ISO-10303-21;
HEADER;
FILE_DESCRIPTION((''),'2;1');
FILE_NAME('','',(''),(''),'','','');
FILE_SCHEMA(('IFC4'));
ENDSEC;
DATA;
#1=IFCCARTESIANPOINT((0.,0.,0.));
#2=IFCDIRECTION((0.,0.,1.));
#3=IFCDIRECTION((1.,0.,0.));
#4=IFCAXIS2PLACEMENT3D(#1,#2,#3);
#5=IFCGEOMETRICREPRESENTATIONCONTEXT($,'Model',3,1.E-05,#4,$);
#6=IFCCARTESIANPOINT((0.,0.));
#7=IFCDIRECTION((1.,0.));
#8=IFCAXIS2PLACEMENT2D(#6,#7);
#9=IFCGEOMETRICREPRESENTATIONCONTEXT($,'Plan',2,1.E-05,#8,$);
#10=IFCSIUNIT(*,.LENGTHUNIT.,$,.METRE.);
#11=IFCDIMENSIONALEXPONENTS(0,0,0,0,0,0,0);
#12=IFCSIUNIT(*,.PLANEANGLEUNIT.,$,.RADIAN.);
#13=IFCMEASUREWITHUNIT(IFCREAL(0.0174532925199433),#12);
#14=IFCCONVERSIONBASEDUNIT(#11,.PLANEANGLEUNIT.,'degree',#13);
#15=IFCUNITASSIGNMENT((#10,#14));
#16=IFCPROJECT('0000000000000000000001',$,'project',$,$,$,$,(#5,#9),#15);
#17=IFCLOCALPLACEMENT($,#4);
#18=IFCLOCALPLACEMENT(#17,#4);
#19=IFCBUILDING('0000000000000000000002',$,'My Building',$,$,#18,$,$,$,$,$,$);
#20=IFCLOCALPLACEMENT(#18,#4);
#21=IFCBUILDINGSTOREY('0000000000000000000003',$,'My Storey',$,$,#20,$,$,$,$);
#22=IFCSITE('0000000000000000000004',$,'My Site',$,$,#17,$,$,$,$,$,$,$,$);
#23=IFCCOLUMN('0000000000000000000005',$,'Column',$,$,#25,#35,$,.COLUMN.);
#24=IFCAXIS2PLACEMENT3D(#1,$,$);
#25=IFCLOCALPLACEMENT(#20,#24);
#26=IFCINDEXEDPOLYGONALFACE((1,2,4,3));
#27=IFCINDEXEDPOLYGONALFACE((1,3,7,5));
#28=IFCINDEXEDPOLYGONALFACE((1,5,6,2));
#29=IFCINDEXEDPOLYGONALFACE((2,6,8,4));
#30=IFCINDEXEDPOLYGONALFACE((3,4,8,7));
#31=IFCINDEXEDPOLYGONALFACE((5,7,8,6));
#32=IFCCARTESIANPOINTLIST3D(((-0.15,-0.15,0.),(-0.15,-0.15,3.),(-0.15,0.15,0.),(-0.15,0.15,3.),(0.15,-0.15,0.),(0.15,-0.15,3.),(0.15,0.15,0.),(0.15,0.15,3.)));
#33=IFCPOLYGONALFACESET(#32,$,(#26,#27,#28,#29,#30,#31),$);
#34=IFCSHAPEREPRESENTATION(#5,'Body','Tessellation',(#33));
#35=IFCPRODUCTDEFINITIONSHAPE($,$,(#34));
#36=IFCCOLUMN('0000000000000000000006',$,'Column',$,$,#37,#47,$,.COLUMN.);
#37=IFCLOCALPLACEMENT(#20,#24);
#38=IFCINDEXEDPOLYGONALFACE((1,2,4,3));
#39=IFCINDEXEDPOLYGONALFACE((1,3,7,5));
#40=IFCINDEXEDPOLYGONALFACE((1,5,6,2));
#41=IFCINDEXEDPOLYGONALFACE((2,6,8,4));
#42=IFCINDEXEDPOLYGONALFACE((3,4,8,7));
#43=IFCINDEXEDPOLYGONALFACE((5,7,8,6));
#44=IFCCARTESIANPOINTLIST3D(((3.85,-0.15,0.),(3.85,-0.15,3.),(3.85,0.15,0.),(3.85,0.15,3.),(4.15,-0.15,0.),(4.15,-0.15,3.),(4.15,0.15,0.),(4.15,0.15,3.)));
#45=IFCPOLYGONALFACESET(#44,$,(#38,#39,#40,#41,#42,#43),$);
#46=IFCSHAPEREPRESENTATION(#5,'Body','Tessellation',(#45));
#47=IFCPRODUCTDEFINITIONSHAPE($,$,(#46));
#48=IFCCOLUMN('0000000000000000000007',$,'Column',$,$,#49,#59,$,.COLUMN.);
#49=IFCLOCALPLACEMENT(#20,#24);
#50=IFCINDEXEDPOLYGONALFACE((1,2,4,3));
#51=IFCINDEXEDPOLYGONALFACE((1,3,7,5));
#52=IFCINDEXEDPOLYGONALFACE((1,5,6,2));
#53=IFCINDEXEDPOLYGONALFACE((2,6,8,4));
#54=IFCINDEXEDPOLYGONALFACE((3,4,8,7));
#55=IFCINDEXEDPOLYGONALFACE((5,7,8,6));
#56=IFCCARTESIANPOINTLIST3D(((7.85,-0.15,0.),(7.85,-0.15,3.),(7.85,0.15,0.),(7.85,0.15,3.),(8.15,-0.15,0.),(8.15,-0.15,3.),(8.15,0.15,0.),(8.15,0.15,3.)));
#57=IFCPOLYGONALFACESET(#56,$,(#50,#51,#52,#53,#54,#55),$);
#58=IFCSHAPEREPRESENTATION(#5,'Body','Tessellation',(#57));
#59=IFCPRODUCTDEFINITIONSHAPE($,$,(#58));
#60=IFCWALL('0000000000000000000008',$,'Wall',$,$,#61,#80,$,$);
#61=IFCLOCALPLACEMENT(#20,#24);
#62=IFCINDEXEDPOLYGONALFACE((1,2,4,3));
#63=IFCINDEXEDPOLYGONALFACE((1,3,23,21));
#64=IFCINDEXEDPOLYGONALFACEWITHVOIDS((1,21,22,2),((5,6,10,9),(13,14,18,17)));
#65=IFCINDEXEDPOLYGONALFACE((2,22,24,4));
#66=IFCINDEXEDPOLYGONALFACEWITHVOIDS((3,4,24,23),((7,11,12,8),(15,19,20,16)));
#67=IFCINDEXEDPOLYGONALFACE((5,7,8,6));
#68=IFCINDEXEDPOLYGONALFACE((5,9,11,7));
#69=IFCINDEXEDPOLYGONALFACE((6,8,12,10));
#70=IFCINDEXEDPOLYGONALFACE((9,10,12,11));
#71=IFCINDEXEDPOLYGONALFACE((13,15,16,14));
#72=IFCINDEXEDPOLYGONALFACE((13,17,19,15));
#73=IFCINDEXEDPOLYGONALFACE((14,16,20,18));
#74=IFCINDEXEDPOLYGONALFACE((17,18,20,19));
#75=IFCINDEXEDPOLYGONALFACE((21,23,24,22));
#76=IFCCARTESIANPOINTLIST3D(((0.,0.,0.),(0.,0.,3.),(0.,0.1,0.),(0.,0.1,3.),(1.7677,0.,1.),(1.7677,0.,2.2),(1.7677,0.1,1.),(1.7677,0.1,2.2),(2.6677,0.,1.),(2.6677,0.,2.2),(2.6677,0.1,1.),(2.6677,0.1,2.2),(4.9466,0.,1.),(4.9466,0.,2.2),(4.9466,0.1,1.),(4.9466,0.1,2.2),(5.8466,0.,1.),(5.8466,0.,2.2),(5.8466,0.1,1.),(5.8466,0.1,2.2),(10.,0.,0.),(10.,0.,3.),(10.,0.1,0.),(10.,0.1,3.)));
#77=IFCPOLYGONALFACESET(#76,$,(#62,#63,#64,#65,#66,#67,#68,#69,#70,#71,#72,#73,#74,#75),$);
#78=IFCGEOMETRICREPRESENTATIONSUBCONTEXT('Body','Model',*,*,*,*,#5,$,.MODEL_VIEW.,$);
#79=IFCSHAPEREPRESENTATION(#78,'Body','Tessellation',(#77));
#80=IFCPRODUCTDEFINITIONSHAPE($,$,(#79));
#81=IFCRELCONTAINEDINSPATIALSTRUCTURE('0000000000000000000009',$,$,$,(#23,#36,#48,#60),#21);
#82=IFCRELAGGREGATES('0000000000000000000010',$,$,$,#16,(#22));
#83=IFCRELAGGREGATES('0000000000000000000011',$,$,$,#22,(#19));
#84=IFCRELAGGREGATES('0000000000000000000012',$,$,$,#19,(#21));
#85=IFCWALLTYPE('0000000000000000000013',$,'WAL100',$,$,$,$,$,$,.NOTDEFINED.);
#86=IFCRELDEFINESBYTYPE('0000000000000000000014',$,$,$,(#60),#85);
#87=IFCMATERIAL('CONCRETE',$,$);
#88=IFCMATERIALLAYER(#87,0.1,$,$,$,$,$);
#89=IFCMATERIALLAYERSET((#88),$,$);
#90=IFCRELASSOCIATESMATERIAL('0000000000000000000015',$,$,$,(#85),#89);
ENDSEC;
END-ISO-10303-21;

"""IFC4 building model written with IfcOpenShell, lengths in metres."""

from ifc_helpers import new_model, entity, si_unit, converted_unit, frame, origin, origin_with_axes, origin_2d, origin_2d_with_axis, place, context, subcontext, project, spatial, line, indexed_curve, rectangle, outline, extrude, source, transform, mapped, material, layer, layer_set, type_object, element, save


model = new_model("IFC4")

# Units and contexts
model_context = context("Model", 3, precision=1e-05, world=origin_with_axes())
plan_context = context("Plan", 2, precision=1e-05, world=origin_2d_with_axis())
body_context = subcontext(model_context, "Body", "Model", "MODEL_VIEW")
ifc_project = project(units=[si_unit("LENGTHUNIT", "METRE"), converted_unit("PLANEANGLEUNIT", "degree", entity("IfcReal", 0.0174532925199433), si_unit("PLANEANGLEUNIT", "RADIAN"), dimensions=[0, 0, 0, 0, 0, 0, 0])], contexts=[model_context, plan_context])

# Site, building, storey
site_placement = place(None, origin_with_axes())
site = spatial("IfcSite", under=ifc_project, at=site_placement, Name="My Site")
building_placement = place(site_placement, origin_with_axes())
building = spatial("IfcBuilding", under=site, at=building_placement, Name="My Building")
storey_placement = place(building_placement, origin_with_axes())
storey = spatial("IfcBuildingStorey", under=building, at=storey_placement, Name="My Storey")

# Columns
for number, where, z_axis, x_axis, name in (
    (1, (0.0, 0.0, 0.0), (0.0, 0.0, 1.0), (1.0, 0.0, 0.0), "Column"),
    (2, (4.0, 0.0, 0.0), (0.0, 0.0, 1.0), (1.0, 0.0, 0.0), "Column"),
    (3, (8.0, 0.0, 0.0), (0.0, 0.0, 1.0), (1.0, 0.0, 0.0), "Column"),
):
    element("IfcColumn", number, at=place(storey_placement, frame(where, z_axis=z_axis, x_axis=x_axis)), inside=storey, Name=name, PredefinedType="COLUMN", context=model_context, shape_type="SweptSolid", body=[
        extrude(rectangle(XDim=0.3, YDim=0.3, at=origin_2d()), origin(), (0.0, 0.0, 1.0), 3.0),
    ])

# Wall, openings
ifc_material = material(Name="CONCRETE")
ifc_layer = layer(ifc_material, 0.1)
ifc_layer_set = layer_set([ifc_layer])
wall_type = type_object("IfcWallType", Name="WAL100", PredefinedType="NOTDEFINED", material=ifc_layer_set)
wall_placement = place(storey_placement, origin_with_axes())
wall = element("IfcWall", 4, at=wall_placement, inside=storey, type_object=wall_type, Name="Wall", context=body_context, shape_type="SweptSolid", body=[
    extrude(outline(indexed_curve([(0.0, 0.0), (0.0, 0.1), (10.0, 0.1), (10.0, 0.0), (0.0, 0.0)], self_intersect=False)), origin_with_axes(), (0.0, 0.0, 1.0), 3.0),
])
shared_shape = source(origin_with_axes(), body_context, "Body", "SweptSolid", [
    extrude(outline(indexed_curve([(0.0, 0.0), (0.9, 0.0), (0.9, 1.2), (0.0, 1.2)], segments=[line(1, 2, 3, 4, 1)])), frame((0.0, -0.6, 0.0), z_axis=(0.0, -1.0, 0.0), x_axis=(1.0, 0.0, 0.0)), (0.0, 0.0, -1.0), 1.2),
])
opening_1_placement = place(wall_placement, frame((1.7677, 0.0, 1.0), z_axis=(0.0, 0.0, 1.0), x_axis=(1.0, 0.0, 0.0)))
element("IfcOpeningElement", 5, at=opening_1_placement, cuts=wall, PredefinedType="OPENING", context=body_context, shape_type="MappedRepresentation", body=[
    mapped(shared_shape, transform((0.0, 0.0, 0.0), x_axis=(1.0, 0.0, 0.0), y_axis=(0.0, 1.0, 0.0), z_axis=(0.0, 0.0, 1.0), scale=1.0)),
])
opening_2_placement = place(wall_placement, frame((4.9466, 0.0, 1.0), z_axis=(0.0, 0.0, 1.0), x_axis=(1.0, 0.0, 0.0)))
element("IfcOpeningElement", 6, at=opening_2_placement, cuts=wall, PredefinedType="OPENING", context=body_context, shape_type="MappedRepresentation", body=[
    mapped(shared_shape, transform((0.0, 0.0, 0.0), x_axis=(1.0, 0.0, 0.0), y_axis=(0.0, 1.0, 0.0), z_axis=(0.0, 0.0, 1.0), scale=1.0)),
])

save(model, "model.ifc")
